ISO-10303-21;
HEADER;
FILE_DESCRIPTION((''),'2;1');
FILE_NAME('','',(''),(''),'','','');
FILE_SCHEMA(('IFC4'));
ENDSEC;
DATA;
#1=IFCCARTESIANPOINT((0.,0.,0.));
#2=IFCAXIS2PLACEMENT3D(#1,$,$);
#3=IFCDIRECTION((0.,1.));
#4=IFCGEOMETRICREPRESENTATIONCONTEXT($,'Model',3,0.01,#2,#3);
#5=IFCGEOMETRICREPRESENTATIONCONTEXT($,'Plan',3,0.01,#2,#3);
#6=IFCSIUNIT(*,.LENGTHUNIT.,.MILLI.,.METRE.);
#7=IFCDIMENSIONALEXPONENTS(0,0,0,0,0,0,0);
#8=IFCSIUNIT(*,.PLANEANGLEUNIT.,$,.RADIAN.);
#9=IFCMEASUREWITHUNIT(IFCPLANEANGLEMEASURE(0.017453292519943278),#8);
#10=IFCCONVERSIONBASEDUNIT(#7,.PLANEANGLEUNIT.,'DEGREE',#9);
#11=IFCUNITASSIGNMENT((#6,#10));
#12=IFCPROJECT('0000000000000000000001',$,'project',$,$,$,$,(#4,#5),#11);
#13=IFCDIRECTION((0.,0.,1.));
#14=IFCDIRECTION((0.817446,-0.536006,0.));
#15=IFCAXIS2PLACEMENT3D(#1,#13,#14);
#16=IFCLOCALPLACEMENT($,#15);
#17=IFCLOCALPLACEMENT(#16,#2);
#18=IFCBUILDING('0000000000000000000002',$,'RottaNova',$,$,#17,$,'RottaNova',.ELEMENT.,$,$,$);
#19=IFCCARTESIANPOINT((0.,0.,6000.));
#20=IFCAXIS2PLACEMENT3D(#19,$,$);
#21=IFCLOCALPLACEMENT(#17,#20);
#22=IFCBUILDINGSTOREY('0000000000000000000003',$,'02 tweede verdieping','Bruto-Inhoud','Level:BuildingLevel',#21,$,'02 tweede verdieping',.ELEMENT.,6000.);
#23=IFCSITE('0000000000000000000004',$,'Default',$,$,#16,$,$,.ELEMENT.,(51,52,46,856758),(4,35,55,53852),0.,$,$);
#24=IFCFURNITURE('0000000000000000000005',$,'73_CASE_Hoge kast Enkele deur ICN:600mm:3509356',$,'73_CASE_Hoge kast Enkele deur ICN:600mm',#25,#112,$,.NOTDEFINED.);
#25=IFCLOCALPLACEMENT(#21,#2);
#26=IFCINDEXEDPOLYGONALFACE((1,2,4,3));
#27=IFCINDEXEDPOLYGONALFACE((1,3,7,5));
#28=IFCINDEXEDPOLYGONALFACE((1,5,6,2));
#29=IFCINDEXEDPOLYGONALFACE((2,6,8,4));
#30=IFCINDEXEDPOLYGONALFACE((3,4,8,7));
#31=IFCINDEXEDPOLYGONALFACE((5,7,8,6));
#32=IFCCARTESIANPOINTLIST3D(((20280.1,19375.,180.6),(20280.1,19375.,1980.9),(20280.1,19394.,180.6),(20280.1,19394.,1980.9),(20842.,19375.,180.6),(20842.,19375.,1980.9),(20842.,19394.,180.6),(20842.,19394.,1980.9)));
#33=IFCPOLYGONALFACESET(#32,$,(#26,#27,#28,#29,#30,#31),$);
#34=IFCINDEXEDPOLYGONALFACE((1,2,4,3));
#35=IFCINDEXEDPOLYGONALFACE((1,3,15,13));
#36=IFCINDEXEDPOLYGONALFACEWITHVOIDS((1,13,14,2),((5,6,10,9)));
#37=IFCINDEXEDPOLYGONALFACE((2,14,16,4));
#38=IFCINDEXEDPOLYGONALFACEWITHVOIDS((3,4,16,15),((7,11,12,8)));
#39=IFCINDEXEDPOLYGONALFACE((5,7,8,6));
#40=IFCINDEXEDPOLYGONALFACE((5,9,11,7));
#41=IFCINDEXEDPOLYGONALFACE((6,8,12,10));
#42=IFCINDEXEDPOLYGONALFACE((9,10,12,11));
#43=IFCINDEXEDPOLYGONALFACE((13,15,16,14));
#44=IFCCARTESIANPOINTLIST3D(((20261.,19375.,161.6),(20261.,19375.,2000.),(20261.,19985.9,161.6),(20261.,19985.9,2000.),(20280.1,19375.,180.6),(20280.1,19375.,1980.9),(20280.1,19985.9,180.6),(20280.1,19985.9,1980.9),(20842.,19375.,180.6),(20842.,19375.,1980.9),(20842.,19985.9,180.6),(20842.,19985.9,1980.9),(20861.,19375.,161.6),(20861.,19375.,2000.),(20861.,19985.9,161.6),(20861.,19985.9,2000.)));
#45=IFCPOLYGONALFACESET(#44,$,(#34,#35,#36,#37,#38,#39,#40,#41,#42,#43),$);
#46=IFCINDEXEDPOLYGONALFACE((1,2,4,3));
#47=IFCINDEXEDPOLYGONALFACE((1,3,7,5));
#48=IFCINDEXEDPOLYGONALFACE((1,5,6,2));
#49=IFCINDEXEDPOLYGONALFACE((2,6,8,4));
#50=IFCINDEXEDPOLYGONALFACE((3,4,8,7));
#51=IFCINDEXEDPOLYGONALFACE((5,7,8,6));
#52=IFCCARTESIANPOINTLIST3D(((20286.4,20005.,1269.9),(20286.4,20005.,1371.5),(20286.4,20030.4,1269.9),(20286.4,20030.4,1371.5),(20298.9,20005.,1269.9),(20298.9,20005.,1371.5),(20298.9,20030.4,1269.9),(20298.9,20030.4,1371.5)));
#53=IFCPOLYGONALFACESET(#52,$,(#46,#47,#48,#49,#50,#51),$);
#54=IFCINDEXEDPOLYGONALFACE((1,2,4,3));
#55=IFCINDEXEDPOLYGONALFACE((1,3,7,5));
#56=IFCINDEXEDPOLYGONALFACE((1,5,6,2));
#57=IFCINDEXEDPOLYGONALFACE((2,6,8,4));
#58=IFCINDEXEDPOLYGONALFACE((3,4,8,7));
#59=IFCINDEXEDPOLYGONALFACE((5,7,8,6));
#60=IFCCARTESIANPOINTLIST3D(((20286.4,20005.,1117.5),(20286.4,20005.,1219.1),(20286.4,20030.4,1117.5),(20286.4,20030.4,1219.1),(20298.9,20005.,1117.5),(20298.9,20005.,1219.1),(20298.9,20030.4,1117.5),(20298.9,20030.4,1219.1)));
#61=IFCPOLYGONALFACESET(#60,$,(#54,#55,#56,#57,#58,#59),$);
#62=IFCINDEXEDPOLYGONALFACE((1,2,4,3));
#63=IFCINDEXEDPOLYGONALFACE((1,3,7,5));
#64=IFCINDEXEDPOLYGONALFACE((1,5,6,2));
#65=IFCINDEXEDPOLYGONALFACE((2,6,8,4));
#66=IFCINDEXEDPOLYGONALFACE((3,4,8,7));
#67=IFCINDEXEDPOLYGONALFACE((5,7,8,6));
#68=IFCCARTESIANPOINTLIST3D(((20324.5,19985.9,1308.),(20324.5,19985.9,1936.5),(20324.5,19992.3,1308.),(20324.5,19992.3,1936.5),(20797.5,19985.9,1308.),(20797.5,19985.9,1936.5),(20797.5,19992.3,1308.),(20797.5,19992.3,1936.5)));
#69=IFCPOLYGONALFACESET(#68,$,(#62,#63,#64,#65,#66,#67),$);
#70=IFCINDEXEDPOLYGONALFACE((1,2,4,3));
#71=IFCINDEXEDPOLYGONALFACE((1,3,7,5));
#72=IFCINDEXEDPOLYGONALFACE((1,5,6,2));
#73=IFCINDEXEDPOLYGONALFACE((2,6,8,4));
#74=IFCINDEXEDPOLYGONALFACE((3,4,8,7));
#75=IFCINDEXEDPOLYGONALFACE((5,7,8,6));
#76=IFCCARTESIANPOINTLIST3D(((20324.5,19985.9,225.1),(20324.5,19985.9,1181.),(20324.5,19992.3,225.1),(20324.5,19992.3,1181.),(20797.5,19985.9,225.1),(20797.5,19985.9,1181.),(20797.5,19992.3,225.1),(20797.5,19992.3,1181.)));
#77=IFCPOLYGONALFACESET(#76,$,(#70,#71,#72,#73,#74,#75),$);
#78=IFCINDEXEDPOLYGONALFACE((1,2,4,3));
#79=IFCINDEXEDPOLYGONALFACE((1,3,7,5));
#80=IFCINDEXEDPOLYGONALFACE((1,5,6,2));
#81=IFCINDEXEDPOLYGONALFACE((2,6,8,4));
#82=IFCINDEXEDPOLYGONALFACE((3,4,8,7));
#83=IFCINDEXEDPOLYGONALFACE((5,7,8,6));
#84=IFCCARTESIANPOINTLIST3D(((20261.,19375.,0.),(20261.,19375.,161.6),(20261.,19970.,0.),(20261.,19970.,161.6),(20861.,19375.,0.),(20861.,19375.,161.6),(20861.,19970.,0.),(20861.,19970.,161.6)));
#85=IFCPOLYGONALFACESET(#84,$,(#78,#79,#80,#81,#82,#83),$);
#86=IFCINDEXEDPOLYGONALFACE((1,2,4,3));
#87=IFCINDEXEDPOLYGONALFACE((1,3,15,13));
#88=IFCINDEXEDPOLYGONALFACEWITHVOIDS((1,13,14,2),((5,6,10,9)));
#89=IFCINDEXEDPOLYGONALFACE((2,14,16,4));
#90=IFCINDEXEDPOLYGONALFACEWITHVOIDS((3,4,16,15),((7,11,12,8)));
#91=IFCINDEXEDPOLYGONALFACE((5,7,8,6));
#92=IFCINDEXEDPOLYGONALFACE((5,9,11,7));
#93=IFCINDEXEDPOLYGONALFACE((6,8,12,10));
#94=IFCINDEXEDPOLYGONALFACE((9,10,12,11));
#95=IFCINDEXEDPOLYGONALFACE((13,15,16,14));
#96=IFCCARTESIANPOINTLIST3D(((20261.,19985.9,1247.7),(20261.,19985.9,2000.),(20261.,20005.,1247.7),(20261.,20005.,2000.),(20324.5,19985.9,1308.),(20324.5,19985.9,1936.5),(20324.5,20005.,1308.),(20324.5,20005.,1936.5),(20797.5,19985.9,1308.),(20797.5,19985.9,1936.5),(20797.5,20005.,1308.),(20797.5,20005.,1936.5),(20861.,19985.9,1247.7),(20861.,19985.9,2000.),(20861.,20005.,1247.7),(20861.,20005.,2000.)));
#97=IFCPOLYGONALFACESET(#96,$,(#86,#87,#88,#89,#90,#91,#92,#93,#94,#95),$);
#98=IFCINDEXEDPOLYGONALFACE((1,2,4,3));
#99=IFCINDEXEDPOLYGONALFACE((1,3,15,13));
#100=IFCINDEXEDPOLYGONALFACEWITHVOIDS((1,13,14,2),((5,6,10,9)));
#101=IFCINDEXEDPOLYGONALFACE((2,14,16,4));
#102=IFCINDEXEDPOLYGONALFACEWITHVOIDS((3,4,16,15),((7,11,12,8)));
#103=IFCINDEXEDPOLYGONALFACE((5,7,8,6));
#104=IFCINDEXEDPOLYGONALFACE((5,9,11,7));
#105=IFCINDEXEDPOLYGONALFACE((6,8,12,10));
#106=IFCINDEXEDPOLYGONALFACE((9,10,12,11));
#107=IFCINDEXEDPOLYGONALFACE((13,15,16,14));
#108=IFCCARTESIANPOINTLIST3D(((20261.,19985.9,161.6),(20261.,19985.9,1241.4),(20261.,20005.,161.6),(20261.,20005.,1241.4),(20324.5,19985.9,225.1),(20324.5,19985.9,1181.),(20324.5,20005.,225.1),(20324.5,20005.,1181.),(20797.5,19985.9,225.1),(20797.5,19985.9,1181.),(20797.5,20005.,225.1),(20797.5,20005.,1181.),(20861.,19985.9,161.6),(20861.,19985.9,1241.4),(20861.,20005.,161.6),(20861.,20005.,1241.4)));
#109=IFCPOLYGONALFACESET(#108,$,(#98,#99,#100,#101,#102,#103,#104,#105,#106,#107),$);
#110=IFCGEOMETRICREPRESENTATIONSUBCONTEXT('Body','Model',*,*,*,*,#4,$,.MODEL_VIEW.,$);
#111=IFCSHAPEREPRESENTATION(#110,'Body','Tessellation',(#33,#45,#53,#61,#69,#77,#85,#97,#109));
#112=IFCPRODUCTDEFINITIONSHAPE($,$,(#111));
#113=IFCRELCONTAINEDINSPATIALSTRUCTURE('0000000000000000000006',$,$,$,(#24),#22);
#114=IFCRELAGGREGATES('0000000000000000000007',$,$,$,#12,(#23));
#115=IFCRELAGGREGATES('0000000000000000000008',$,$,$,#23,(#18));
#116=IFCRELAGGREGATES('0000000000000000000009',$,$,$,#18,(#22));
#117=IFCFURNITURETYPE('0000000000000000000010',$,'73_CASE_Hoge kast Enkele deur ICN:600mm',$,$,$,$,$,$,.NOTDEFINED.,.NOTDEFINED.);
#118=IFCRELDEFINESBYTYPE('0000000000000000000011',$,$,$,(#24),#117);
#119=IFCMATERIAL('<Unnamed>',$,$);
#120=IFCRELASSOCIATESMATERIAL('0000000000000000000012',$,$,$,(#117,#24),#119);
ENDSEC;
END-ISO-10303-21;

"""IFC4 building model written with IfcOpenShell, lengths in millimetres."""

from ifc_helpers import new_model, entity, si_unit, converted_unit, direction, frame, origin, place, context, subcontext, project, spatial, indexed_curve, outline, extrude, source, transform, mapped, material, type_object, type_shapes, element, save


model = new_model("IFC4")

# Units and contexts
model_context = context("Model", 3, precision=0.01, world=origin(), true_north=direction((0.0, 1.0)))
plan_context = context("Plan", 3, precision=0.01, world=origin(), true_north=direction((0.0, 1.0)))
body_context = subcontext(model_context, "Body", "Model", "MODEL_VIEW")
ifc_project = project(units=[si_unit("LENGTHUNIT", "METRE", prefix="MILLI"), converted_unit("PLANEANGLEUNIT", "DEGREE", entity("IfcPlaneAngleMeasure", 0.017453292519943278), si_unit("PLANEANGLEUNIT", "RADIAN"), dimensions=[0, 0, 0, 0, 0, 0, 0])], contexts=[model_context, plan_context])

# Site, building, storey
site_placement = place(None, frame((0.0, 0.0, 0.0), z_axis=(0.0, 0.0, 1.0), x_axis=(0.817446, -0.536006, 0.0)))
site = spatial("IfcSite", under=ifc_project, at=site_placement, Name="Default", CompositionType="ELEMENT", RefLatitude=(51, 52, 46, 856758), RefLongitude=(4, 35, 55, 53852), RefElevation=0.0)
building_placement = place(site_placement, origin())
building = spatial("IfcBuilding", under=site, at=building_placement, Name="RottaNova", LongName="RottaNova", CompositionType="ELEMENT")
storey_placement = place(building_placement, frame((0.0, 0.0, 6000.0)))
storey = spatial("IfcBuildingStorey", under=building, at=storey_placement, Name="02 tweede verdieping", Description="Bruto-Inhoud", ObjectType="Level:BuildingLevel", LongName="02 tweede verdieping", CompositionType="ELEMENT", Elevation=6000.0)

# Furniture
ifc_material_1 = material(Name="<Unnamed>")
furniture_type = type_object("IfcFurnitureType", Name="73_CASE_Hoge kast Enkele deur ICN:600mm", AssemblyPlace="NOTDEFINED", PredefinedType="NOTDEFINED", material=ifc_material_1)
shared_shape_1 = source(origin(), body_context, "Body", "SweptSolid", [
    extrude(outline(indexed_curve([(-9.5, -280.9), (9.5, -280.9), (9.5, 280.9), (-9.5, 280.9), (-9.5, -280.9)], self_intersect=False)), frame((18.7, -9.5, 180.6), z_axis=(0.0, 0.0, 1.0), x_axis=(0.0, 1.0, 0.0)), (0.0, 0.0, 1.0), 1800.3),
    extrude(outline(indexed_curve([(-300.0, -919.2), (300.0, -919.2), (300.0, 919.2), (-300.0, 919.2), (-300.0, -919.2)], self_intersect=False), holes=[indexed_curve([(-280.9, 900.2), (281.0, 900.2), (281.0, -900.2), (-280.9, -900.2), (-280.9, 900.2)], self_intersect=False)]), frame((18.7, -610.9, 1080.8), z_axis=(0.0, 1.0, 0.0), x_axis=(-1.0, 0.0, 0.0)), (0.0, 0.0, 1.0), 610.9),
    extrude(outline(indexed_curve([(-12.7, -6.3), (12.7, -6.3), (12.7, 6.3), (-12.7, 6.3), (-12.7, -6.3)], self_intersect=False)), frame((287.1, -642.7, 1269.9), z_axis=(0.0, 0.0, 1.0), x_axis=(0.0, 1.0, 0.0)), (0.0, 0.0, 1.0), 101.6),
    extrude(outline(indexed_curve([(-12.7, -6.3), (12.7, -6.3), (12.7, 6.3), (-12.7, 6.3), (-12.7, -6.3)], self_intersect=False)), frame((287.1, -642.7, 1117.5), z_axis=(0.0, 0.0, 1.0), x_axis=(0.0, 1.0, 0.0)), (0.0, 0.0, 1.0), 101.6),
    extrude(outline(indexed_curve([(-3.2, -236.5), (3.2, -236.5), (3.2, 236.5), (-3.2, 236.5), (-3.2, -236.5)], self_intersect=False)), frame((18.7, -614.1, 1308.0), z_axis=(0.0, 0.0, 1.0), x_axis=(0.0, 1.0, 0.0)), (0.0, 0.0, 1.0), 628.5),
    extrude(outline(indexed_curve([(-3.2, -236.5), (3.2, -236.5), (3.2, 236.5), (-3.2, 236.5), (-3.2, -236.5)], self_intersect=False)), frame((18.7, -614.1, 225.1), z_axis=(0.0, 0.0, 1.0), x_axis=(0.0, 1.0, 0.0)), (0.0, 0.0, 1.0), 956.0),
    extrude(outline(indexed_curve([(-300.0, -297.5), (300.0, -297.5), (300.0, 297.5), (-300.0, 297.5), (-300.0, -297.5)], self_intersect=False)), frame((18.7, -297.5, 0.0), z_axis=(0.0, 0.0, 1.0), x_axis=(-1.0, 0.0, 0.0)), (0.0, 0.0, 1.0), 161.6),
    extrude(outline(indexed_curve([(-376.1, -300.0), (376.1, -300.0), (376.1, 300.0), (-376.1, 300.0), (-376.1, -300.0)], self_intersect=False), holes=[indexed_curve([(-312.6, -236.5), (-312.6, 236.5), (315.8, 236.5), (315.8, -236.5), (-312.6, -236.5)], self_intersect=False)]), frame((18.7, -630.0, 1623.9), z_axis=(0.0, 1.0, 0.0), x_axis=(0.0, 0.0, -1.0)), (0.0, 0.0, 1.0), 19.1),
    extrude(outline(indexed_curve([(-300.0, -539.9), (300.0, -539.9), (300.0, 539.9), (-300.0, 539.9), (-300.0, -539.9)], self_intersect=False), holes=[indexed_curve([(-236.5, 479.6), (236.5, 479.6), (236.5, -476.4), (-236.5, -476.4), (-236.5, 479.6)], self_intersect=False)]), frame((18.7, -630.0, 701.5), z_axis=(0.0, 1.0, 0.0), x_axis=(-1.0, 0.0, 0.0)), (0.0, 0.0, 1.0), 19.1),
])
type_shapes(furniture_type, [shared_shape_1])
furniture_placement = place(storey_placement, frame((20579.7, 19375.0, 0.0), z_axis=(0.0, 0.0, 1.0), x_axis=(-1.0, 0.0, 0.0)))
element("IfcFurniture", 1, at=furniture_placement, inside=storey, type_object=furniture_type, material=ifc_material_1, Name="73_CASE_Hoge kast Enkele deur ICN:600mm:3509356", ObjectType="73_CASE_Hoge kast Enkele deur ICN:600mm", PredefinedType="NOTDEFINED", context=body_context, shape_type="MappedRepresentation", body=[
    mapped(shared_shape_1, transform((0.0, 0.0, 0.0), scale=1.0)),
])

save(model, "model.ifc")
